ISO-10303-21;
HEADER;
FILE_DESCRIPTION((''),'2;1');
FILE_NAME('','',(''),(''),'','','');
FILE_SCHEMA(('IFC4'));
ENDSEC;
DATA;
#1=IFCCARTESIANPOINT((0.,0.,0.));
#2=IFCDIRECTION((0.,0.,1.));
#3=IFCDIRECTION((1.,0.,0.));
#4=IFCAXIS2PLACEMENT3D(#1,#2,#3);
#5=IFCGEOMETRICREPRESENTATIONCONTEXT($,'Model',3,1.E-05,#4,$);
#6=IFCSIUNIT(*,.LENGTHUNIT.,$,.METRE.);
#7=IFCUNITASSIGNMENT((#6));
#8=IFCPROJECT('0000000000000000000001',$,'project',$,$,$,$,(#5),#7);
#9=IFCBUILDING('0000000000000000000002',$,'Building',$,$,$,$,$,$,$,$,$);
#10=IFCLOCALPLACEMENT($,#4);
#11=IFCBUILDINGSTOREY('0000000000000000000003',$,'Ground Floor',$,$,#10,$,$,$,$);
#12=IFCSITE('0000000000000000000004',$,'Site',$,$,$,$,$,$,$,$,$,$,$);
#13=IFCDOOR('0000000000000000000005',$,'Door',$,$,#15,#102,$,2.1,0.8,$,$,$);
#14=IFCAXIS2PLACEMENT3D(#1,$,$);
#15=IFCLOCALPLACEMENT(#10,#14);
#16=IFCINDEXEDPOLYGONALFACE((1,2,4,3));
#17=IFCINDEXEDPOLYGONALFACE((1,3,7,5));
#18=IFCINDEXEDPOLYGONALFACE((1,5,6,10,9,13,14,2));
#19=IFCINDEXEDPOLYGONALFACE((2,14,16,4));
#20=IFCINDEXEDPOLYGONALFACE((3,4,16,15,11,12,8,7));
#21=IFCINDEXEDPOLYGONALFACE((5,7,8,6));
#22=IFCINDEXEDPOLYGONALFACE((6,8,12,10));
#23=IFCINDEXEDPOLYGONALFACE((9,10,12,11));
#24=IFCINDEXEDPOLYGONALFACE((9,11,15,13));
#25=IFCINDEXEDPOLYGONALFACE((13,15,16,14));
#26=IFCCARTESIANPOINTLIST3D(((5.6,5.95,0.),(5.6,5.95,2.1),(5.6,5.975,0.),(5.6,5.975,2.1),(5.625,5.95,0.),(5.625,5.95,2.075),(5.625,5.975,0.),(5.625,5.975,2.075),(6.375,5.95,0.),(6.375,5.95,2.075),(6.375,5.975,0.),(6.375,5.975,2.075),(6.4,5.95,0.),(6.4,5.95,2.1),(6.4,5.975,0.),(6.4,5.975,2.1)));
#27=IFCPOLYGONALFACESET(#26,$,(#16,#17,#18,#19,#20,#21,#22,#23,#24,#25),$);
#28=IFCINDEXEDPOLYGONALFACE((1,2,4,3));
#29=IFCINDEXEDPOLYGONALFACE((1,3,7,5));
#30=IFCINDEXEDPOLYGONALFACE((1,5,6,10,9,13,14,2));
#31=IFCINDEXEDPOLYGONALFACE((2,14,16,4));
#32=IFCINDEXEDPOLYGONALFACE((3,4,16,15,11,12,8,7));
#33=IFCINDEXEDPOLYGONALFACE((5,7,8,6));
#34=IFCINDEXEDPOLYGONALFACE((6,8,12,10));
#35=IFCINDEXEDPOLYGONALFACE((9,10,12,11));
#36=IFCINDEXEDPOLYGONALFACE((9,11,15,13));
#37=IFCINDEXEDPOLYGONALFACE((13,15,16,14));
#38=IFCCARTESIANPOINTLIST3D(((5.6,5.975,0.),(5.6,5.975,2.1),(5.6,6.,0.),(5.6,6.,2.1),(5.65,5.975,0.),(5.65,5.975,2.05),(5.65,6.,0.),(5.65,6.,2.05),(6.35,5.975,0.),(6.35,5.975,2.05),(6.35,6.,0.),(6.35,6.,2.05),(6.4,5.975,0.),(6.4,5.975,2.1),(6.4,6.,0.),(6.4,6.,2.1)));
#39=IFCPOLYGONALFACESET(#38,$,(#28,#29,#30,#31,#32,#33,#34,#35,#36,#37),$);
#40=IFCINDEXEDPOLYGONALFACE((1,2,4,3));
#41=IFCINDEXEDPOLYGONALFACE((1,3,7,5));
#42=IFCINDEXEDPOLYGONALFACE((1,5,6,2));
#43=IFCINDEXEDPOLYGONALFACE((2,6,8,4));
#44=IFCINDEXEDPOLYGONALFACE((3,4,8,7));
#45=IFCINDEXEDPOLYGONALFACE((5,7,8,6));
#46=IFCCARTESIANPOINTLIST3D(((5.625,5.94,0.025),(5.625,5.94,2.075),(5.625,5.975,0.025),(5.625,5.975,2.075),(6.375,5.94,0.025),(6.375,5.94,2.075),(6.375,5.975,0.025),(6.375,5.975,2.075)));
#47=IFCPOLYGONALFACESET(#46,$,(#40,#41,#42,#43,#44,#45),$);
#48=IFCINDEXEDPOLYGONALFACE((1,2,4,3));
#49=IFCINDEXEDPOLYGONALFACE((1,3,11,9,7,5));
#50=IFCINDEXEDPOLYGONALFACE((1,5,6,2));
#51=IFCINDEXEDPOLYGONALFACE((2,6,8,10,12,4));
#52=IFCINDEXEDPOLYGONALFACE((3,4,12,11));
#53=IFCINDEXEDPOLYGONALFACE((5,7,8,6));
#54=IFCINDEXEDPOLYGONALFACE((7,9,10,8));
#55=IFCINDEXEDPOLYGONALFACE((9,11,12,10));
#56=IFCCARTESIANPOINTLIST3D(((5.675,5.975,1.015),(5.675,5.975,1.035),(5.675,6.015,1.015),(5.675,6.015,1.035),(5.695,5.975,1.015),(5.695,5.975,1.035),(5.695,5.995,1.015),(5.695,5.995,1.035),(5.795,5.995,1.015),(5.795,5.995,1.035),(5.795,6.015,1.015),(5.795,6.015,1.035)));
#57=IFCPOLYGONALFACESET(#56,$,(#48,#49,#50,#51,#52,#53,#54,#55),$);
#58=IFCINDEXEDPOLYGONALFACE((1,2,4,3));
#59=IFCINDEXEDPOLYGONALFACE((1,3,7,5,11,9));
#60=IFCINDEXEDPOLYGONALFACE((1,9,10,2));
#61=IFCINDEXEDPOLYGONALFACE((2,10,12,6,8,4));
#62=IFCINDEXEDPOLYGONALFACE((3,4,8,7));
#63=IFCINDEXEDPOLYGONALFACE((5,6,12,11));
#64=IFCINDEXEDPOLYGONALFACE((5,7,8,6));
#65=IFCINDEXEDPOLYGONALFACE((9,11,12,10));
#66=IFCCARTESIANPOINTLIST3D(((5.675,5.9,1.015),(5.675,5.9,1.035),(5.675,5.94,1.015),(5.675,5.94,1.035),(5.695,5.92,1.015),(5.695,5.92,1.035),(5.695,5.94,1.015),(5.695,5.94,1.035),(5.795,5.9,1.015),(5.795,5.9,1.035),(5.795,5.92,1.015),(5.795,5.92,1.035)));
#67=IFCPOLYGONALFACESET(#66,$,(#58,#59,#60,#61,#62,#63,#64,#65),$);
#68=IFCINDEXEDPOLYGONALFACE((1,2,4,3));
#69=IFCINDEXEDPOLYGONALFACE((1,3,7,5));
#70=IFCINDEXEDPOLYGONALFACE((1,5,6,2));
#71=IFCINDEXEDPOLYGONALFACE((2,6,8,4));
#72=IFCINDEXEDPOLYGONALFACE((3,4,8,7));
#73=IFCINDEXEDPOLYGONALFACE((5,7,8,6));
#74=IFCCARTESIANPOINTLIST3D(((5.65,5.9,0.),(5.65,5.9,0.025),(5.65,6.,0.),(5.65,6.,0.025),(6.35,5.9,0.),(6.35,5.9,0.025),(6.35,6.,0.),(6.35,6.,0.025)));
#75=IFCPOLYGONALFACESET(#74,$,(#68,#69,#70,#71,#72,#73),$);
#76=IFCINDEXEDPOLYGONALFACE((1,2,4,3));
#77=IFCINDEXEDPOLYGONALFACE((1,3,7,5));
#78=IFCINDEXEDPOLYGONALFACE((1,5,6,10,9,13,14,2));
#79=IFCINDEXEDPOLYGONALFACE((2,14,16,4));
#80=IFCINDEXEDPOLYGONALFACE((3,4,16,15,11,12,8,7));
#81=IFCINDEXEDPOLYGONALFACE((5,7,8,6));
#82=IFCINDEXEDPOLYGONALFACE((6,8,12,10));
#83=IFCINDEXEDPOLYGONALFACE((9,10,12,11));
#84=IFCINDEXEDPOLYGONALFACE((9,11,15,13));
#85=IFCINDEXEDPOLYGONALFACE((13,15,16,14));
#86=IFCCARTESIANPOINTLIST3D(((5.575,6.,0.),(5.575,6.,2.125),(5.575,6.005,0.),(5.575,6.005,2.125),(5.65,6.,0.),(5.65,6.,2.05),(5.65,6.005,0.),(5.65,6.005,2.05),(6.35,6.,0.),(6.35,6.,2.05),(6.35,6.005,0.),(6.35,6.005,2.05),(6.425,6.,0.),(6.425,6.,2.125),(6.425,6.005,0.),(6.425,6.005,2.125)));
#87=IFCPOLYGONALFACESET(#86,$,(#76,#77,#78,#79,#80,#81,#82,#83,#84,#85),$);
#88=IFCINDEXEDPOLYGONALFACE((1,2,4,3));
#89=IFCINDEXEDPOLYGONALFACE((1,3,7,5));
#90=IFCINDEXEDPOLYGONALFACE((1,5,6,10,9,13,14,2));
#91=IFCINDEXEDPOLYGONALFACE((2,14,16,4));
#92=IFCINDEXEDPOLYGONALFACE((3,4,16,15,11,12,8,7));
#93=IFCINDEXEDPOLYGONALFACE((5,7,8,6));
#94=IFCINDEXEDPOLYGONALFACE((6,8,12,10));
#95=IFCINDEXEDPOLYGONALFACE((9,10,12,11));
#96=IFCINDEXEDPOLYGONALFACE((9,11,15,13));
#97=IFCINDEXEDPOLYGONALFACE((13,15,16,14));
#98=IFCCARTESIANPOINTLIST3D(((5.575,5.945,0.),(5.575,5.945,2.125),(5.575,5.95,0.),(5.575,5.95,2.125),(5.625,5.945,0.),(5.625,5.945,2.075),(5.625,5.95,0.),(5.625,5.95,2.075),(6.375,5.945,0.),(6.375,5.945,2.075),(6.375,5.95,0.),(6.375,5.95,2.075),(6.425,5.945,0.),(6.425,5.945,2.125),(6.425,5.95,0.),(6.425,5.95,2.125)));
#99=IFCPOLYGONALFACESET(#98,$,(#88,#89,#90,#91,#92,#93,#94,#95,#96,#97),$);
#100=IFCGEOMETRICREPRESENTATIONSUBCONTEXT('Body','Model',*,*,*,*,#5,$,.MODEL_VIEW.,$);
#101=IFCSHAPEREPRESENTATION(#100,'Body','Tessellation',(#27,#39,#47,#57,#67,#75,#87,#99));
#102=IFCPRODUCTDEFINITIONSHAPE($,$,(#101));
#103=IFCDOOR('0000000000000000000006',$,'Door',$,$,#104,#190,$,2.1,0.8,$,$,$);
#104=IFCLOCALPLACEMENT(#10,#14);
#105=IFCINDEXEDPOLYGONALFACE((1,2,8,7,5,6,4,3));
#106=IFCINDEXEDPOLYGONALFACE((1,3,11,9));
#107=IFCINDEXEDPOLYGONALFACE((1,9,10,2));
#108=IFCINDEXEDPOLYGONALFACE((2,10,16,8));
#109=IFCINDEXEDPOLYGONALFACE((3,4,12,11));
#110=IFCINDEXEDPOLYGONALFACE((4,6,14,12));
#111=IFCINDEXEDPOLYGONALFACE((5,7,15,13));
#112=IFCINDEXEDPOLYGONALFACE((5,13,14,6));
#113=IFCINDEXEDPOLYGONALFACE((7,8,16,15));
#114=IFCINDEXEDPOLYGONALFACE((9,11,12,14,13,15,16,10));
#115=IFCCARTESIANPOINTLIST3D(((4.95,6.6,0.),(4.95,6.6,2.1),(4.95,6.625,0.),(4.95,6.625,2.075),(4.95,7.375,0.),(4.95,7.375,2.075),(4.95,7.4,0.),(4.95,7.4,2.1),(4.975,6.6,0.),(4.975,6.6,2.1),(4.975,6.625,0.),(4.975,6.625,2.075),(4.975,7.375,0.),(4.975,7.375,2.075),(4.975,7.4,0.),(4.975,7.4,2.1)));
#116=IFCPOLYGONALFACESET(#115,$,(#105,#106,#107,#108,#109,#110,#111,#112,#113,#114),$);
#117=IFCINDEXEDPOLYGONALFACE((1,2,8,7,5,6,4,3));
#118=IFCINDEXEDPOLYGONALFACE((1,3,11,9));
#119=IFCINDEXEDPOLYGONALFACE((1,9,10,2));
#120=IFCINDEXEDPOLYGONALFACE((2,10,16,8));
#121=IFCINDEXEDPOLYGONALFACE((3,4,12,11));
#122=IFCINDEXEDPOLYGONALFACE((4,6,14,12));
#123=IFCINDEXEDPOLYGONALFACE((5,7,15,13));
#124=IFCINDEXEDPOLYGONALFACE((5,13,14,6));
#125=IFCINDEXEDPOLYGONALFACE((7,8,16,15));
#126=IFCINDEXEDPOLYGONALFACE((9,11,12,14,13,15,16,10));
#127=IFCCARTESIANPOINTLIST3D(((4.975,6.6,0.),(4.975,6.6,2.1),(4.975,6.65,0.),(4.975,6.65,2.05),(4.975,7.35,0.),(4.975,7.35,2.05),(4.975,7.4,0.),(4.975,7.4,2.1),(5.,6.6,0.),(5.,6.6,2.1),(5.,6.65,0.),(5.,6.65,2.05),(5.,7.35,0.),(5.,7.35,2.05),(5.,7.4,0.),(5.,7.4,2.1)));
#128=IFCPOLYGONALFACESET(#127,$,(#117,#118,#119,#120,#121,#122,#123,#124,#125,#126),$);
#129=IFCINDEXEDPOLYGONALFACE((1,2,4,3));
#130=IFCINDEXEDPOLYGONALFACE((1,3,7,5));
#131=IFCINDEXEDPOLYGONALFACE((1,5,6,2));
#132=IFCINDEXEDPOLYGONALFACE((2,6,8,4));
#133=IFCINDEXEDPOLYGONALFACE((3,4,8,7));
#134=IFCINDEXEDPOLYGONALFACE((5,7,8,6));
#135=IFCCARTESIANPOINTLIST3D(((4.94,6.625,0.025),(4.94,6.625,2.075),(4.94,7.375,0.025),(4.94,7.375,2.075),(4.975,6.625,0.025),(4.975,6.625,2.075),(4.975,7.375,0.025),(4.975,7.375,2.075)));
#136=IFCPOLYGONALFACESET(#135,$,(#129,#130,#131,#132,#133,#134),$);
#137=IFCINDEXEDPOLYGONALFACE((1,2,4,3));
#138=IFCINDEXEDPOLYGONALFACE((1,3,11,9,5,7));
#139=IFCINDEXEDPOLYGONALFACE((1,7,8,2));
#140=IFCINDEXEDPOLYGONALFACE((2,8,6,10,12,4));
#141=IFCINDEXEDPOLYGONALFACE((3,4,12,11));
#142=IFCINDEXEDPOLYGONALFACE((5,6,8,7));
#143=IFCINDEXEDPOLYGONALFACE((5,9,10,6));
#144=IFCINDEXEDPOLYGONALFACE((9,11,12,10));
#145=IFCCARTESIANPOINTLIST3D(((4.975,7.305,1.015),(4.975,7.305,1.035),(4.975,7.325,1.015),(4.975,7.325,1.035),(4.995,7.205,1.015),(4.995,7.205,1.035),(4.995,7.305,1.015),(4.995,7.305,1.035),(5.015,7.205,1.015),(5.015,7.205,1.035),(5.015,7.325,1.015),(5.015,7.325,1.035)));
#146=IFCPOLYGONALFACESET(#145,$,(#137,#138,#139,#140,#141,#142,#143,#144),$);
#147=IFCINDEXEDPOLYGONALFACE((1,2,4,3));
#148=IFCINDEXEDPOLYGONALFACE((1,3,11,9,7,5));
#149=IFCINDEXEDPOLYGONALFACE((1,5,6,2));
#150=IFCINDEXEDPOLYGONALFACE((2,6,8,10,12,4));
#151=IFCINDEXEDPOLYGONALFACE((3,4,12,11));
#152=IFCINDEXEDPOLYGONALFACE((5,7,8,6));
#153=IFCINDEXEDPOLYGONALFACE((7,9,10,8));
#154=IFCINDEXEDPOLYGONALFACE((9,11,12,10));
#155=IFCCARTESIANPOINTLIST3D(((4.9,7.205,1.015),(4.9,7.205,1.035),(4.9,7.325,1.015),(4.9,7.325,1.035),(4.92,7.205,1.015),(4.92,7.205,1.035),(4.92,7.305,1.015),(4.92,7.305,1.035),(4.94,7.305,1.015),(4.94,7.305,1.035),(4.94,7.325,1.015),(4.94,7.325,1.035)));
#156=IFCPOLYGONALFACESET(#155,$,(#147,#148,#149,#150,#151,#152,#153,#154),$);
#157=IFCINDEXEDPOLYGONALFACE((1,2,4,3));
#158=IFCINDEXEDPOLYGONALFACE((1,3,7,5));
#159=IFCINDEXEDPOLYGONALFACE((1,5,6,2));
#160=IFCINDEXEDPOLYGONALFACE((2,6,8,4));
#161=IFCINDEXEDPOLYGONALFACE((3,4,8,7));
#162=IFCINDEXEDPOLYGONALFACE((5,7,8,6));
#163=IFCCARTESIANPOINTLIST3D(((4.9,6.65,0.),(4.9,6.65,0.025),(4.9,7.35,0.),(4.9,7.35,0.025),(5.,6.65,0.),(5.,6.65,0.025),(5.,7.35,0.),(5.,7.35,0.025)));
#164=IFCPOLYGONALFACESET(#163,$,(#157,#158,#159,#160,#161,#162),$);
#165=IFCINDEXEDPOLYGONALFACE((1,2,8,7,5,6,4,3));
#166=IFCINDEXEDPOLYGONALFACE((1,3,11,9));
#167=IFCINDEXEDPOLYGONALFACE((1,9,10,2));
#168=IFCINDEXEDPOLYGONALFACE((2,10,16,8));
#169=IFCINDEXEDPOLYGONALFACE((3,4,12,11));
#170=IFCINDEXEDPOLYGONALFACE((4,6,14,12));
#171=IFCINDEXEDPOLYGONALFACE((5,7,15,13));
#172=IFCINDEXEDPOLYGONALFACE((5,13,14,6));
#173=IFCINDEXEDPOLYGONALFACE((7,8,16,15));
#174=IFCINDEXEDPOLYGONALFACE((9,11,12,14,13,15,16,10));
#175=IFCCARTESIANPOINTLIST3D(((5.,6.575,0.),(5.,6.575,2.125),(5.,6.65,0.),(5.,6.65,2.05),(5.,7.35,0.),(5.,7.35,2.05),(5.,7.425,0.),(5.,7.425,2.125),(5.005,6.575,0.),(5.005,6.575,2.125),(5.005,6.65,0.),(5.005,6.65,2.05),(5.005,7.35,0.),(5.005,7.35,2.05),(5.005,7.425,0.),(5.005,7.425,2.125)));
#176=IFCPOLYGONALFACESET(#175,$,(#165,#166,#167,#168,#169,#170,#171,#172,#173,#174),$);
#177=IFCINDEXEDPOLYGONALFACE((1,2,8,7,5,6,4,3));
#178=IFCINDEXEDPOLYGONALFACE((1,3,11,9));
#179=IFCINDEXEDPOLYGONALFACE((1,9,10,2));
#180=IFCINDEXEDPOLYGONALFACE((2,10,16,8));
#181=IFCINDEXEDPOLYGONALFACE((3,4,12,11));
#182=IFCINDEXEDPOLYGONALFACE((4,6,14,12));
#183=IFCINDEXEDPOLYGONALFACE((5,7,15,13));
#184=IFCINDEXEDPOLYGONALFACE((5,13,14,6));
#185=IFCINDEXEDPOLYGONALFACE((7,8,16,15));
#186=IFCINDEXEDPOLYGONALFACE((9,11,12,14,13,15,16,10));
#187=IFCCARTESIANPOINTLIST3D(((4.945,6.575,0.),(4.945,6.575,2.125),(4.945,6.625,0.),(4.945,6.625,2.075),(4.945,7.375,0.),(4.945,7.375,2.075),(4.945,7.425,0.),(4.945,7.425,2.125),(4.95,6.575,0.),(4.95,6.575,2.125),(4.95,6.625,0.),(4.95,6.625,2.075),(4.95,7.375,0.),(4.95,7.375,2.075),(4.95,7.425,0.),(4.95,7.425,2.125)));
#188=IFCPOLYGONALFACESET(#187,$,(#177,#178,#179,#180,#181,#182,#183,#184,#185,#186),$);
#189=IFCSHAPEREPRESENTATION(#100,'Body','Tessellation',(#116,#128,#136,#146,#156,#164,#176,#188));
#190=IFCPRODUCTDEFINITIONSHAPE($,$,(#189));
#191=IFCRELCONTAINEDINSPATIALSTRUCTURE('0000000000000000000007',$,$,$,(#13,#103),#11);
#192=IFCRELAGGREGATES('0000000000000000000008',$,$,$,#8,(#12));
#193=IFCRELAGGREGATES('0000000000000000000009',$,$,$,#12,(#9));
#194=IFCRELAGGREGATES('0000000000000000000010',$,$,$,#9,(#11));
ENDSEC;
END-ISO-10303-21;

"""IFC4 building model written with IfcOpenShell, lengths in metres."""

from ifc_helpers import new_model, si_unit, frame, origin_with_axes, place, context, subcontext, project, spatial, line, indexed_curve, outline, extrude, element, save


model = new_model("IFC4")

# Units and contexts
model_context = context("Model", 3, precision=1e-05, world=origin_with_axes())
body_context = subcontext(model_context, "Body", "Model", "MODEL_VIEW")
ifc_project = project(units=[si_unit("LENGTHUNIT", "METRE")], contexts=[model_context])

# Site, building, storey
site = spatial("IfcSite", under=ifc_project, Name="Site")
building = spatial("IfcBuilding", under=site, Name="Building")
storey_placement = place(None, origin_with_axes())
storey = spatial("IfcBuildingStorey", under=building, at=storey_placement, Name="Ground Floor")

# Doors
door_1_placement = place(storey_placement, frame((6.4, 6.0, 0.0), z_axis=(0.0, 0.0, 1.0), x_axis=(-1.0, 0.0, 0.0)))
element("IfcDoor", 1, at=door_1_placement, inside=storey, Name="Door", OverallHeight=2.1, OverallWidth=0.8, context=body_context, shape_type="SweptSolid", body=[
    extrude(outline(indexed_curve([(0.0, 0.0), (0.0, 2.1), (0.8, 2.1), (0.8, 0.0), (0.775, 0.0), (0.775, 2.075), (0.025, 2.075), (0.025, 0.0)], segments=[line(1, 2, 3, 4, 5, 6, 7, 8, 1)])), frame((0.0, 0.025, 0.0), z_axis=(0.0, -1.0, 0.0), x_axis=(1.0, 0.0, 0.0)), (0.0, 0.0, -1.0), 0.025),
    extrude(outline(indexed_curve([(0.0, 0.0), (0.0, 2.1), (0.8, 2.1), (0.8, 0.0), (0.75, 0.0), (0.75, 2.05), (0.05, 2.05), (0.05, 0.0)], segments=[line(1, 2, 3, 4, 5, 6, 7, 8, 1)])), frame((0.0, 0.0, 0.0), z_axis=(0.0, -1.0, 0.0), x_axis=(1.0, 0.0, 0.0)), (0.0, 0.0, -1.0), 0.025),
    extrude(outline(indexed_curve([(0.0, 0.0), (0.75, 0.0), (0.75, 0.035), (0.0, 0.035)], segments=[line(1, 2, 3, 4, 1)])), frame((0.025, 0.025, 0.025), z_axis=(0.0, 0.0, 1.0), x_axis=(1.0, 0.0, 0.0)), (0.0, 0.0, 1.0), 2.05),
    extrude(outline(indexed_curve([(0.0, 0.0), (0.0, -0.04), (-0.12, -0.04), (-0.12, -0.02), (-0.02, -0.02), (-0.02, 0.0)], segments=[line(1, 2, 3, 4, 5, 6, 1)])), frame((0.725, 0.025, 1.015), z_axis=(0.0, 0.0, 1.0), x_axis=(1.0, 0.0, 0.0)), (0.0, 0.0, 1.0), 0.02),
    extrude(outline(indexed_curve([(0.0, 0.0), (0.0, 0.04), (-0.12, 0.04), (-0.12, 0.02), (-0.02, 0.02), (-0.02, 0.0)], segments=[line(1, 2, 3, 4, 5, 6, 1)])), frame((0.725, 0.06, 1.015), z_axis=(0.0, 0.0, 1.0), x_axis=(1.0, 0.0, 0.0)), (0.0, 0.0, 1.0), 0.02),
    extrude(outline(indexed_curve([(0.0, 0.0), (0.7, 0.0), (0.7, 0.1), (0.0, 0.1)], segments=[line(1, 2, 3, 4, 1)])), frame((0.05, 0.0, 0.0), z_axis=(0.0, 0.0, 1.0), x_axis=(1.0, 0.0, 0.0)), (0.0, 0.0, 1.0), 0.025),
    extrude(outline(indexed_curve([(0.0, 0.0), (0.0, 2.125), (0.85, 2.125), (0.85, 0.0), (0.775, 0.0), (0.775, 2.05), (0.075, 2.05), (0.075, 0.0)], segments=[line(1, 2, 3, 4, 5, 6, 7, 8, 1)])), frame((-0.025, -0.005, 0.0), z_axis=(0.0, -1.0, 0.0), x_axis=(1.0, 0.0, 0.0)), (0.0, 0.0, -1.0), 0.005),
    extrude(outline(indexed_curve([(0.0, 0.0), (0.0, 2.125), (0.85, 2.125), (0.85, 0.0), (0.8, 0.0), (0.8, 2.075), (0.05, 2.075), (0.05, 0.0)], segments=[line(1, 2, 3, 4, 5, 6, 7, 8, 1)])), frame((-0.025, 0.05, 0.0), z_axis=(0.0, -1.0, 0.0), x_axis=(1.0, 0.0, 0.0)), (0.0, 0.0, -1.0), 0.005),
])
door_2_placement = place(storey_placement, frame((5.0, 6.6, 0.0), z_axis=(0.0, 0.0, 1.0), x_axis=(0.0, 1.0, 0.0)))
element("IfcDoor", 2, at=door_2_placement, inside=storey, Name="Door", OverallHeight=2.1, OverallWidth=0.8, context=body_context, shape_type="SweptSolid", body=[
    extrude(outline(indexed_curve([(0.0, 0.0), (0.0, 2.1), (0.8, 2.1), (0.8, 0.0), (0.775, 0.0), (0.775, 2.075), (0.025, 2.075), (0.025, 0.0)], segments=[line(1, 2, 3, 4, 5, 6, 7, 8, 1)])), frame((0.0, 0.025, 0.0), z_axis=(0.0, -1.0, 0.0), x_axis=(1.0, 0.0, 0.0)), (0.0, 0.0, -1.0), 0.025),
    extrude(outline(indexed_curve([(0.0, 0.0), (0.0, 2.1), (0.8, 2.1), (0.8, 0.0), (0.75, 0.0), (0.75, 2.05), (0.05, 2.05), (0.05, 0.0)], segments=[line(1, 2, 3, 4, 5, 6, 7, 8, 1)])), frame((0.0, 0.0, 0.0), z_axis=(0.0, -1.0, 0.0), x_axis=(1.0, 0.0, 0.0)), (0.0, 0.0, -1.0), 0.025),
    extrude(outline(indexed_curve([(0.0, 0.0), (0.75, 0.0), (0.75, 0.035), (0.0, 0.035)], segments=[line(1, 2, 3, 4, 1)])), frame((0.025, 0.025, 0.025), z_axis=(0.0, 0.0, 1.0), x_axis=(1.0, 0.0, 0.0)), (0.0, 0.0, 1.0), 2.05),
    extrude(outline(indexed_curve([(0.0, 0.0), (0.0, -0.04), (-0.12, -0.04), (-0.12, -0.02), (-0.02, -0.02), (-0.02, 0.0)], segments=[line(1, 2, 3, 4, 5, 6, 1)])), frame((0.725, 0.025, 1.015), z_axis=(0.0, 0.0, 1.0), x_axis=(1.0, 0.0, 0.0)), (0.0, 0.0, 1.0), 0.02),
    extrude(outline(indexed_curve([(0.0, 0.0), (0.0, 0.04), (-0.12, 0.04), (-0.12, 0.02), (-0.02, 0.02), (-0.02, 0.0)], segments=[line(1, 2, 3, 4, 5, 6, 1)])), frame((0.725, 0.06, 1.015), z_axis=(0.0, 0.0, 1.0), x_axis=(1.0, 0.0, 0.0)), (0.0, 0.0, 1.0), 0.02),
    extrude(outline(indexed_curve([(0.0, 0.0), (0.7, 0.0), (0.7, 0.1), (0.0, 0.1)], segments=[line(1, 2, 3, 4, 1)])), frame((0.05, 0.0, 0.0), z_axis=(0.0, 0.0, 1.0), x_axis=(1.0, 0.0, 0.0)), (0.0, 0.0, 1.0), 0.025),
    extrude(outline(indexed_curve([(0.0, 0.0), (0.0, 2.125), (0.85, 2.125), (0.85, 0.0), (0.775, 0.0), (0.775, 2.05), (0.075, 2.05), (0.075, 0.0)], segments=[line(1, 2, 3, 4, 5, 6, 7, 8, 1)])), frame((-0.025, -0.005, 0.0), z_axis=(0.0, -1.0, 0.0), x_axis=(1.0, 0.0, 0.0)), (0.0, 0.0, -1.0), 0.005),
    extrude(outline(indexed_curve([(0.0, 0.0), (0.0, 2.125), (0.85, 2.125), (0.85, 0.0), (0.8, 0.0), (0.8, 2.075), (0.05, 2.075), (0.05, 0.0)], segments=[line(1, 2, 3, 4, 5, 6, 7, 8, 1)])), frame((-0.025, 0.05, 0.0), z_axis=(0.0, -1.0, 0.0), x_axis=(1.0, 0.0, 0.0)), (0.0, 0.0, -1.0), 0.005),
])

save(model, "model.ifc")
